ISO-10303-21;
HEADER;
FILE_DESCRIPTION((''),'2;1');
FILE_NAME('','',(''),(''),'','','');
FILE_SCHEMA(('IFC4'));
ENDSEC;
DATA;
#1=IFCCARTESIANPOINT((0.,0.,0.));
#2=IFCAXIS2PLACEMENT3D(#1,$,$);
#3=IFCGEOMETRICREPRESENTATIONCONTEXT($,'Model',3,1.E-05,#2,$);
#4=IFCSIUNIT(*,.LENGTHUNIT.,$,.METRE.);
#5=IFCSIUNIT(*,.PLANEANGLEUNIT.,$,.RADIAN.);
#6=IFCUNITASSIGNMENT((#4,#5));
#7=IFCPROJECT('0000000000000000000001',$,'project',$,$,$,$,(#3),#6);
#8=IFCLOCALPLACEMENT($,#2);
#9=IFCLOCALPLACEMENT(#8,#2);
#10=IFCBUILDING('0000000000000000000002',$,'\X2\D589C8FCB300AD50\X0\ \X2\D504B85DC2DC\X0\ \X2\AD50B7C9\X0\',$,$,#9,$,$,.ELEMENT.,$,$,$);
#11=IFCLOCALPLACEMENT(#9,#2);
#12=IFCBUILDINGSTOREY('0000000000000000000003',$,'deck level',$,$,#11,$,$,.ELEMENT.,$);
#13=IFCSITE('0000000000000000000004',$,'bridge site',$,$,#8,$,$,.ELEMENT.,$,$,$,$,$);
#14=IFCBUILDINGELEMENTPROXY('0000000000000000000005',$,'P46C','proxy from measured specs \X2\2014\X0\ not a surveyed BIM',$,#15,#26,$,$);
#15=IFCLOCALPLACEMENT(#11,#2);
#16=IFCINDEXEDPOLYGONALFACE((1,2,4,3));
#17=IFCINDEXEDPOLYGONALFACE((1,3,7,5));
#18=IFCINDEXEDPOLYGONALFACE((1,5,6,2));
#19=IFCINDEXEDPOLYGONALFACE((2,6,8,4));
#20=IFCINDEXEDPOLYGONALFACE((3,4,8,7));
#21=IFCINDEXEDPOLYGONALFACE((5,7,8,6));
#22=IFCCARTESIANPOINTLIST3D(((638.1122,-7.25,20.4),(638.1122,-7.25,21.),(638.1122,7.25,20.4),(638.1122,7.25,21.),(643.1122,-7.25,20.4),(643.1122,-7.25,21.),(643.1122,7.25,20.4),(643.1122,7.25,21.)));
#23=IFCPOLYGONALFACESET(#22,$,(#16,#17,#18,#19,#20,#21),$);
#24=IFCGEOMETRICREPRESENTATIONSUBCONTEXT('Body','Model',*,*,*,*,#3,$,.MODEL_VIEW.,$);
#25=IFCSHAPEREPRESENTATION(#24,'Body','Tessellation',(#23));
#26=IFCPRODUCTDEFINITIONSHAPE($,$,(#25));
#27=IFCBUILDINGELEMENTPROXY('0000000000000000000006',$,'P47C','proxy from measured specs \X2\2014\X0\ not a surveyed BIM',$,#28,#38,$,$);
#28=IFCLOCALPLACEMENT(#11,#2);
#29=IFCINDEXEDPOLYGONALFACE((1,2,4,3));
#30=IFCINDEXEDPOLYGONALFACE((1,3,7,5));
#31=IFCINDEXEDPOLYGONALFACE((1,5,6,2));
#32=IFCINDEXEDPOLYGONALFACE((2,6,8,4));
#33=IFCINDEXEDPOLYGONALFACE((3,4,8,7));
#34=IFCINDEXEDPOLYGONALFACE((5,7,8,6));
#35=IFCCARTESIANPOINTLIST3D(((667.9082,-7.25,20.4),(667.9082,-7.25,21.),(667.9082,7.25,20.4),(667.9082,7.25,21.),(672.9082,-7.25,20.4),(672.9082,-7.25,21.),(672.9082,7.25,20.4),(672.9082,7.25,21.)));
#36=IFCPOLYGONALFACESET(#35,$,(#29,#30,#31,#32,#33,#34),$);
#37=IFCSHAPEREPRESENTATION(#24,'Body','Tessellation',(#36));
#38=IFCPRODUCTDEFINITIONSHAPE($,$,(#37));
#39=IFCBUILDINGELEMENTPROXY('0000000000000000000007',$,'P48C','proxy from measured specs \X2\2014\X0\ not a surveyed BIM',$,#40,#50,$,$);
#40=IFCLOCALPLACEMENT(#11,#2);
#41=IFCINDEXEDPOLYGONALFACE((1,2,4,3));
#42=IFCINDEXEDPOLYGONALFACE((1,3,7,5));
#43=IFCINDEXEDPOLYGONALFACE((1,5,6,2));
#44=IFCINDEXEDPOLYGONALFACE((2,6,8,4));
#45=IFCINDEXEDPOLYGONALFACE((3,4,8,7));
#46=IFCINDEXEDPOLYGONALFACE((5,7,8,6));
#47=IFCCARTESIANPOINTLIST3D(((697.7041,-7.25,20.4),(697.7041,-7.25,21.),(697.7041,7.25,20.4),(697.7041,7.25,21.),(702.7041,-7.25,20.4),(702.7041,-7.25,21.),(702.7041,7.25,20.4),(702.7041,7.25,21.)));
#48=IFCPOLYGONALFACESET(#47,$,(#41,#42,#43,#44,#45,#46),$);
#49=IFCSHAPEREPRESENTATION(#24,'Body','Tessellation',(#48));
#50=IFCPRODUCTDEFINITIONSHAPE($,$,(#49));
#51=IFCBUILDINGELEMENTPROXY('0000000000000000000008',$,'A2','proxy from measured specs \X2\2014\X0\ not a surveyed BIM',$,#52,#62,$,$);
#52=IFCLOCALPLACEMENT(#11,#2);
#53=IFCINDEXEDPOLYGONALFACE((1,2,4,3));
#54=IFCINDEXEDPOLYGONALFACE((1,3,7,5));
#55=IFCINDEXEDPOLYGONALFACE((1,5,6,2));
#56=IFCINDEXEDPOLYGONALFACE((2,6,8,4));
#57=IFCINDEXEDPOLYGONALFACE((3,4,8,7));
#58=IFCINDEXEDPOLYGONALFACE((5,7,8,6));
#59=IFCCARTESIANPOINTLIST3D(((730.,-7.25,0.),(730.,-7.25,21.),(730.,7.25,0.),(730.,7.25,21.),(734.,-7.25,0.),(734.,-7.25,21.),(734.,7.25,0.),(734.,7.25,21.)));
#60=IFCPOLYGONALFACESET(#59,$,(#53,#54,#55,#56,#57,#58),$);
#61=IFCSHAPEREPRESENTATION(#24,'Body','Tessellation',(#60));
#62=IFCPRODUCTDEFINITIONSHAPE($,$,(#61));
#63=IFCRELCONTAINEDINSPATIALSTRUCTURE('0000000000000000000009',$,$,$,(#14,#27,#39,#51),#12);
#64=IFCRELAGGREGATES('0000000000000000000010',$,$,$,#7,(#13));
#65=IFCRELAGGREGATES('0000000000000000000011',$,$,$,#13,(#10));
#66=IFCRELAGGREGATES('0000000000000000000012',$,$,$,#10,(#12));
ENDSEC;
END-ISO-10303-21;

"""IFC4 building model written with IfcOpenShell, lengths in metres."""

from ifc_helpers import new_model, si_unit, frame, origin, origin_2d, place, context, subcontext, project, spatial, rectangle, extrude, element, save


model = new_model("IFC4")

# Units and contexts
model_context = context("Model", 3, precision=1e-05, world=origin())
body_context = subcontext(model_context, "Body", "Model", "MODEL_VIEW")
ifc_project = project(units=[si_unit("LENGTHUNIT", "METRE"), si_unit("PLANEANGLEUNIT", "RADIAN")], contexts=[model_context])

# Site, building, storey
site_placement = place(None, origin())
site = spatial("IfcSite", under=ifc_project, at=site_placement, Name="bridge site", CompositionType="ELEMENT")
building_placement = place(site_placement, origin())
building = spatial("IfcBuilding", under=site, at=building_placement, Name="행주대교 프록시 교량", CompositionType="ELEMENT")
storey_placement = place(building_placement, origin())
storey = spatial("IfcBuildingStorey", under=building, at=storey_placement, Name="deck level", CompositionType="ELEMENT")

# Building element proxies
for number, where, name in (
    (1, (640.6122, 0.0, 20.4), "P46C"),
    (2, (670.4082, 0.0, 20.4), "P47C"),
    (3, (700.2041, 0.0, 20.4), "P48C"),
):
    element("IfcBuildingElementProxy", number, at=place(storey_placement, frame(where)), inside=storey, Name=name, Description="proxy from measured specs — not a surveyed BIM", context=body_context, shape_type="SweptSolid", body=[
        extrude(rectangle(XDim=5.0, YDim=14.5, at=origin_2d()), origin(), (0.0, 0.0, 1.0), 0.6),
    ])
proxy_placement = place(storey_placement, frame((732.0, 0.0, 0.0)))
element("IfcBuildingElementProxy", 4, at=proxy_placement, inside=storey, Name="A2", Description="proxy from measured specs — not a surveyed BIM", context=body_context, shape_type="SweptSolid", body=[
    extrude(rectangle(XDim=4.0, YDim=14.5, at=origin_2d()), origin(), (0.0, 0.0, 1.0), 21.0),
])

save(model, "model.ifc")
